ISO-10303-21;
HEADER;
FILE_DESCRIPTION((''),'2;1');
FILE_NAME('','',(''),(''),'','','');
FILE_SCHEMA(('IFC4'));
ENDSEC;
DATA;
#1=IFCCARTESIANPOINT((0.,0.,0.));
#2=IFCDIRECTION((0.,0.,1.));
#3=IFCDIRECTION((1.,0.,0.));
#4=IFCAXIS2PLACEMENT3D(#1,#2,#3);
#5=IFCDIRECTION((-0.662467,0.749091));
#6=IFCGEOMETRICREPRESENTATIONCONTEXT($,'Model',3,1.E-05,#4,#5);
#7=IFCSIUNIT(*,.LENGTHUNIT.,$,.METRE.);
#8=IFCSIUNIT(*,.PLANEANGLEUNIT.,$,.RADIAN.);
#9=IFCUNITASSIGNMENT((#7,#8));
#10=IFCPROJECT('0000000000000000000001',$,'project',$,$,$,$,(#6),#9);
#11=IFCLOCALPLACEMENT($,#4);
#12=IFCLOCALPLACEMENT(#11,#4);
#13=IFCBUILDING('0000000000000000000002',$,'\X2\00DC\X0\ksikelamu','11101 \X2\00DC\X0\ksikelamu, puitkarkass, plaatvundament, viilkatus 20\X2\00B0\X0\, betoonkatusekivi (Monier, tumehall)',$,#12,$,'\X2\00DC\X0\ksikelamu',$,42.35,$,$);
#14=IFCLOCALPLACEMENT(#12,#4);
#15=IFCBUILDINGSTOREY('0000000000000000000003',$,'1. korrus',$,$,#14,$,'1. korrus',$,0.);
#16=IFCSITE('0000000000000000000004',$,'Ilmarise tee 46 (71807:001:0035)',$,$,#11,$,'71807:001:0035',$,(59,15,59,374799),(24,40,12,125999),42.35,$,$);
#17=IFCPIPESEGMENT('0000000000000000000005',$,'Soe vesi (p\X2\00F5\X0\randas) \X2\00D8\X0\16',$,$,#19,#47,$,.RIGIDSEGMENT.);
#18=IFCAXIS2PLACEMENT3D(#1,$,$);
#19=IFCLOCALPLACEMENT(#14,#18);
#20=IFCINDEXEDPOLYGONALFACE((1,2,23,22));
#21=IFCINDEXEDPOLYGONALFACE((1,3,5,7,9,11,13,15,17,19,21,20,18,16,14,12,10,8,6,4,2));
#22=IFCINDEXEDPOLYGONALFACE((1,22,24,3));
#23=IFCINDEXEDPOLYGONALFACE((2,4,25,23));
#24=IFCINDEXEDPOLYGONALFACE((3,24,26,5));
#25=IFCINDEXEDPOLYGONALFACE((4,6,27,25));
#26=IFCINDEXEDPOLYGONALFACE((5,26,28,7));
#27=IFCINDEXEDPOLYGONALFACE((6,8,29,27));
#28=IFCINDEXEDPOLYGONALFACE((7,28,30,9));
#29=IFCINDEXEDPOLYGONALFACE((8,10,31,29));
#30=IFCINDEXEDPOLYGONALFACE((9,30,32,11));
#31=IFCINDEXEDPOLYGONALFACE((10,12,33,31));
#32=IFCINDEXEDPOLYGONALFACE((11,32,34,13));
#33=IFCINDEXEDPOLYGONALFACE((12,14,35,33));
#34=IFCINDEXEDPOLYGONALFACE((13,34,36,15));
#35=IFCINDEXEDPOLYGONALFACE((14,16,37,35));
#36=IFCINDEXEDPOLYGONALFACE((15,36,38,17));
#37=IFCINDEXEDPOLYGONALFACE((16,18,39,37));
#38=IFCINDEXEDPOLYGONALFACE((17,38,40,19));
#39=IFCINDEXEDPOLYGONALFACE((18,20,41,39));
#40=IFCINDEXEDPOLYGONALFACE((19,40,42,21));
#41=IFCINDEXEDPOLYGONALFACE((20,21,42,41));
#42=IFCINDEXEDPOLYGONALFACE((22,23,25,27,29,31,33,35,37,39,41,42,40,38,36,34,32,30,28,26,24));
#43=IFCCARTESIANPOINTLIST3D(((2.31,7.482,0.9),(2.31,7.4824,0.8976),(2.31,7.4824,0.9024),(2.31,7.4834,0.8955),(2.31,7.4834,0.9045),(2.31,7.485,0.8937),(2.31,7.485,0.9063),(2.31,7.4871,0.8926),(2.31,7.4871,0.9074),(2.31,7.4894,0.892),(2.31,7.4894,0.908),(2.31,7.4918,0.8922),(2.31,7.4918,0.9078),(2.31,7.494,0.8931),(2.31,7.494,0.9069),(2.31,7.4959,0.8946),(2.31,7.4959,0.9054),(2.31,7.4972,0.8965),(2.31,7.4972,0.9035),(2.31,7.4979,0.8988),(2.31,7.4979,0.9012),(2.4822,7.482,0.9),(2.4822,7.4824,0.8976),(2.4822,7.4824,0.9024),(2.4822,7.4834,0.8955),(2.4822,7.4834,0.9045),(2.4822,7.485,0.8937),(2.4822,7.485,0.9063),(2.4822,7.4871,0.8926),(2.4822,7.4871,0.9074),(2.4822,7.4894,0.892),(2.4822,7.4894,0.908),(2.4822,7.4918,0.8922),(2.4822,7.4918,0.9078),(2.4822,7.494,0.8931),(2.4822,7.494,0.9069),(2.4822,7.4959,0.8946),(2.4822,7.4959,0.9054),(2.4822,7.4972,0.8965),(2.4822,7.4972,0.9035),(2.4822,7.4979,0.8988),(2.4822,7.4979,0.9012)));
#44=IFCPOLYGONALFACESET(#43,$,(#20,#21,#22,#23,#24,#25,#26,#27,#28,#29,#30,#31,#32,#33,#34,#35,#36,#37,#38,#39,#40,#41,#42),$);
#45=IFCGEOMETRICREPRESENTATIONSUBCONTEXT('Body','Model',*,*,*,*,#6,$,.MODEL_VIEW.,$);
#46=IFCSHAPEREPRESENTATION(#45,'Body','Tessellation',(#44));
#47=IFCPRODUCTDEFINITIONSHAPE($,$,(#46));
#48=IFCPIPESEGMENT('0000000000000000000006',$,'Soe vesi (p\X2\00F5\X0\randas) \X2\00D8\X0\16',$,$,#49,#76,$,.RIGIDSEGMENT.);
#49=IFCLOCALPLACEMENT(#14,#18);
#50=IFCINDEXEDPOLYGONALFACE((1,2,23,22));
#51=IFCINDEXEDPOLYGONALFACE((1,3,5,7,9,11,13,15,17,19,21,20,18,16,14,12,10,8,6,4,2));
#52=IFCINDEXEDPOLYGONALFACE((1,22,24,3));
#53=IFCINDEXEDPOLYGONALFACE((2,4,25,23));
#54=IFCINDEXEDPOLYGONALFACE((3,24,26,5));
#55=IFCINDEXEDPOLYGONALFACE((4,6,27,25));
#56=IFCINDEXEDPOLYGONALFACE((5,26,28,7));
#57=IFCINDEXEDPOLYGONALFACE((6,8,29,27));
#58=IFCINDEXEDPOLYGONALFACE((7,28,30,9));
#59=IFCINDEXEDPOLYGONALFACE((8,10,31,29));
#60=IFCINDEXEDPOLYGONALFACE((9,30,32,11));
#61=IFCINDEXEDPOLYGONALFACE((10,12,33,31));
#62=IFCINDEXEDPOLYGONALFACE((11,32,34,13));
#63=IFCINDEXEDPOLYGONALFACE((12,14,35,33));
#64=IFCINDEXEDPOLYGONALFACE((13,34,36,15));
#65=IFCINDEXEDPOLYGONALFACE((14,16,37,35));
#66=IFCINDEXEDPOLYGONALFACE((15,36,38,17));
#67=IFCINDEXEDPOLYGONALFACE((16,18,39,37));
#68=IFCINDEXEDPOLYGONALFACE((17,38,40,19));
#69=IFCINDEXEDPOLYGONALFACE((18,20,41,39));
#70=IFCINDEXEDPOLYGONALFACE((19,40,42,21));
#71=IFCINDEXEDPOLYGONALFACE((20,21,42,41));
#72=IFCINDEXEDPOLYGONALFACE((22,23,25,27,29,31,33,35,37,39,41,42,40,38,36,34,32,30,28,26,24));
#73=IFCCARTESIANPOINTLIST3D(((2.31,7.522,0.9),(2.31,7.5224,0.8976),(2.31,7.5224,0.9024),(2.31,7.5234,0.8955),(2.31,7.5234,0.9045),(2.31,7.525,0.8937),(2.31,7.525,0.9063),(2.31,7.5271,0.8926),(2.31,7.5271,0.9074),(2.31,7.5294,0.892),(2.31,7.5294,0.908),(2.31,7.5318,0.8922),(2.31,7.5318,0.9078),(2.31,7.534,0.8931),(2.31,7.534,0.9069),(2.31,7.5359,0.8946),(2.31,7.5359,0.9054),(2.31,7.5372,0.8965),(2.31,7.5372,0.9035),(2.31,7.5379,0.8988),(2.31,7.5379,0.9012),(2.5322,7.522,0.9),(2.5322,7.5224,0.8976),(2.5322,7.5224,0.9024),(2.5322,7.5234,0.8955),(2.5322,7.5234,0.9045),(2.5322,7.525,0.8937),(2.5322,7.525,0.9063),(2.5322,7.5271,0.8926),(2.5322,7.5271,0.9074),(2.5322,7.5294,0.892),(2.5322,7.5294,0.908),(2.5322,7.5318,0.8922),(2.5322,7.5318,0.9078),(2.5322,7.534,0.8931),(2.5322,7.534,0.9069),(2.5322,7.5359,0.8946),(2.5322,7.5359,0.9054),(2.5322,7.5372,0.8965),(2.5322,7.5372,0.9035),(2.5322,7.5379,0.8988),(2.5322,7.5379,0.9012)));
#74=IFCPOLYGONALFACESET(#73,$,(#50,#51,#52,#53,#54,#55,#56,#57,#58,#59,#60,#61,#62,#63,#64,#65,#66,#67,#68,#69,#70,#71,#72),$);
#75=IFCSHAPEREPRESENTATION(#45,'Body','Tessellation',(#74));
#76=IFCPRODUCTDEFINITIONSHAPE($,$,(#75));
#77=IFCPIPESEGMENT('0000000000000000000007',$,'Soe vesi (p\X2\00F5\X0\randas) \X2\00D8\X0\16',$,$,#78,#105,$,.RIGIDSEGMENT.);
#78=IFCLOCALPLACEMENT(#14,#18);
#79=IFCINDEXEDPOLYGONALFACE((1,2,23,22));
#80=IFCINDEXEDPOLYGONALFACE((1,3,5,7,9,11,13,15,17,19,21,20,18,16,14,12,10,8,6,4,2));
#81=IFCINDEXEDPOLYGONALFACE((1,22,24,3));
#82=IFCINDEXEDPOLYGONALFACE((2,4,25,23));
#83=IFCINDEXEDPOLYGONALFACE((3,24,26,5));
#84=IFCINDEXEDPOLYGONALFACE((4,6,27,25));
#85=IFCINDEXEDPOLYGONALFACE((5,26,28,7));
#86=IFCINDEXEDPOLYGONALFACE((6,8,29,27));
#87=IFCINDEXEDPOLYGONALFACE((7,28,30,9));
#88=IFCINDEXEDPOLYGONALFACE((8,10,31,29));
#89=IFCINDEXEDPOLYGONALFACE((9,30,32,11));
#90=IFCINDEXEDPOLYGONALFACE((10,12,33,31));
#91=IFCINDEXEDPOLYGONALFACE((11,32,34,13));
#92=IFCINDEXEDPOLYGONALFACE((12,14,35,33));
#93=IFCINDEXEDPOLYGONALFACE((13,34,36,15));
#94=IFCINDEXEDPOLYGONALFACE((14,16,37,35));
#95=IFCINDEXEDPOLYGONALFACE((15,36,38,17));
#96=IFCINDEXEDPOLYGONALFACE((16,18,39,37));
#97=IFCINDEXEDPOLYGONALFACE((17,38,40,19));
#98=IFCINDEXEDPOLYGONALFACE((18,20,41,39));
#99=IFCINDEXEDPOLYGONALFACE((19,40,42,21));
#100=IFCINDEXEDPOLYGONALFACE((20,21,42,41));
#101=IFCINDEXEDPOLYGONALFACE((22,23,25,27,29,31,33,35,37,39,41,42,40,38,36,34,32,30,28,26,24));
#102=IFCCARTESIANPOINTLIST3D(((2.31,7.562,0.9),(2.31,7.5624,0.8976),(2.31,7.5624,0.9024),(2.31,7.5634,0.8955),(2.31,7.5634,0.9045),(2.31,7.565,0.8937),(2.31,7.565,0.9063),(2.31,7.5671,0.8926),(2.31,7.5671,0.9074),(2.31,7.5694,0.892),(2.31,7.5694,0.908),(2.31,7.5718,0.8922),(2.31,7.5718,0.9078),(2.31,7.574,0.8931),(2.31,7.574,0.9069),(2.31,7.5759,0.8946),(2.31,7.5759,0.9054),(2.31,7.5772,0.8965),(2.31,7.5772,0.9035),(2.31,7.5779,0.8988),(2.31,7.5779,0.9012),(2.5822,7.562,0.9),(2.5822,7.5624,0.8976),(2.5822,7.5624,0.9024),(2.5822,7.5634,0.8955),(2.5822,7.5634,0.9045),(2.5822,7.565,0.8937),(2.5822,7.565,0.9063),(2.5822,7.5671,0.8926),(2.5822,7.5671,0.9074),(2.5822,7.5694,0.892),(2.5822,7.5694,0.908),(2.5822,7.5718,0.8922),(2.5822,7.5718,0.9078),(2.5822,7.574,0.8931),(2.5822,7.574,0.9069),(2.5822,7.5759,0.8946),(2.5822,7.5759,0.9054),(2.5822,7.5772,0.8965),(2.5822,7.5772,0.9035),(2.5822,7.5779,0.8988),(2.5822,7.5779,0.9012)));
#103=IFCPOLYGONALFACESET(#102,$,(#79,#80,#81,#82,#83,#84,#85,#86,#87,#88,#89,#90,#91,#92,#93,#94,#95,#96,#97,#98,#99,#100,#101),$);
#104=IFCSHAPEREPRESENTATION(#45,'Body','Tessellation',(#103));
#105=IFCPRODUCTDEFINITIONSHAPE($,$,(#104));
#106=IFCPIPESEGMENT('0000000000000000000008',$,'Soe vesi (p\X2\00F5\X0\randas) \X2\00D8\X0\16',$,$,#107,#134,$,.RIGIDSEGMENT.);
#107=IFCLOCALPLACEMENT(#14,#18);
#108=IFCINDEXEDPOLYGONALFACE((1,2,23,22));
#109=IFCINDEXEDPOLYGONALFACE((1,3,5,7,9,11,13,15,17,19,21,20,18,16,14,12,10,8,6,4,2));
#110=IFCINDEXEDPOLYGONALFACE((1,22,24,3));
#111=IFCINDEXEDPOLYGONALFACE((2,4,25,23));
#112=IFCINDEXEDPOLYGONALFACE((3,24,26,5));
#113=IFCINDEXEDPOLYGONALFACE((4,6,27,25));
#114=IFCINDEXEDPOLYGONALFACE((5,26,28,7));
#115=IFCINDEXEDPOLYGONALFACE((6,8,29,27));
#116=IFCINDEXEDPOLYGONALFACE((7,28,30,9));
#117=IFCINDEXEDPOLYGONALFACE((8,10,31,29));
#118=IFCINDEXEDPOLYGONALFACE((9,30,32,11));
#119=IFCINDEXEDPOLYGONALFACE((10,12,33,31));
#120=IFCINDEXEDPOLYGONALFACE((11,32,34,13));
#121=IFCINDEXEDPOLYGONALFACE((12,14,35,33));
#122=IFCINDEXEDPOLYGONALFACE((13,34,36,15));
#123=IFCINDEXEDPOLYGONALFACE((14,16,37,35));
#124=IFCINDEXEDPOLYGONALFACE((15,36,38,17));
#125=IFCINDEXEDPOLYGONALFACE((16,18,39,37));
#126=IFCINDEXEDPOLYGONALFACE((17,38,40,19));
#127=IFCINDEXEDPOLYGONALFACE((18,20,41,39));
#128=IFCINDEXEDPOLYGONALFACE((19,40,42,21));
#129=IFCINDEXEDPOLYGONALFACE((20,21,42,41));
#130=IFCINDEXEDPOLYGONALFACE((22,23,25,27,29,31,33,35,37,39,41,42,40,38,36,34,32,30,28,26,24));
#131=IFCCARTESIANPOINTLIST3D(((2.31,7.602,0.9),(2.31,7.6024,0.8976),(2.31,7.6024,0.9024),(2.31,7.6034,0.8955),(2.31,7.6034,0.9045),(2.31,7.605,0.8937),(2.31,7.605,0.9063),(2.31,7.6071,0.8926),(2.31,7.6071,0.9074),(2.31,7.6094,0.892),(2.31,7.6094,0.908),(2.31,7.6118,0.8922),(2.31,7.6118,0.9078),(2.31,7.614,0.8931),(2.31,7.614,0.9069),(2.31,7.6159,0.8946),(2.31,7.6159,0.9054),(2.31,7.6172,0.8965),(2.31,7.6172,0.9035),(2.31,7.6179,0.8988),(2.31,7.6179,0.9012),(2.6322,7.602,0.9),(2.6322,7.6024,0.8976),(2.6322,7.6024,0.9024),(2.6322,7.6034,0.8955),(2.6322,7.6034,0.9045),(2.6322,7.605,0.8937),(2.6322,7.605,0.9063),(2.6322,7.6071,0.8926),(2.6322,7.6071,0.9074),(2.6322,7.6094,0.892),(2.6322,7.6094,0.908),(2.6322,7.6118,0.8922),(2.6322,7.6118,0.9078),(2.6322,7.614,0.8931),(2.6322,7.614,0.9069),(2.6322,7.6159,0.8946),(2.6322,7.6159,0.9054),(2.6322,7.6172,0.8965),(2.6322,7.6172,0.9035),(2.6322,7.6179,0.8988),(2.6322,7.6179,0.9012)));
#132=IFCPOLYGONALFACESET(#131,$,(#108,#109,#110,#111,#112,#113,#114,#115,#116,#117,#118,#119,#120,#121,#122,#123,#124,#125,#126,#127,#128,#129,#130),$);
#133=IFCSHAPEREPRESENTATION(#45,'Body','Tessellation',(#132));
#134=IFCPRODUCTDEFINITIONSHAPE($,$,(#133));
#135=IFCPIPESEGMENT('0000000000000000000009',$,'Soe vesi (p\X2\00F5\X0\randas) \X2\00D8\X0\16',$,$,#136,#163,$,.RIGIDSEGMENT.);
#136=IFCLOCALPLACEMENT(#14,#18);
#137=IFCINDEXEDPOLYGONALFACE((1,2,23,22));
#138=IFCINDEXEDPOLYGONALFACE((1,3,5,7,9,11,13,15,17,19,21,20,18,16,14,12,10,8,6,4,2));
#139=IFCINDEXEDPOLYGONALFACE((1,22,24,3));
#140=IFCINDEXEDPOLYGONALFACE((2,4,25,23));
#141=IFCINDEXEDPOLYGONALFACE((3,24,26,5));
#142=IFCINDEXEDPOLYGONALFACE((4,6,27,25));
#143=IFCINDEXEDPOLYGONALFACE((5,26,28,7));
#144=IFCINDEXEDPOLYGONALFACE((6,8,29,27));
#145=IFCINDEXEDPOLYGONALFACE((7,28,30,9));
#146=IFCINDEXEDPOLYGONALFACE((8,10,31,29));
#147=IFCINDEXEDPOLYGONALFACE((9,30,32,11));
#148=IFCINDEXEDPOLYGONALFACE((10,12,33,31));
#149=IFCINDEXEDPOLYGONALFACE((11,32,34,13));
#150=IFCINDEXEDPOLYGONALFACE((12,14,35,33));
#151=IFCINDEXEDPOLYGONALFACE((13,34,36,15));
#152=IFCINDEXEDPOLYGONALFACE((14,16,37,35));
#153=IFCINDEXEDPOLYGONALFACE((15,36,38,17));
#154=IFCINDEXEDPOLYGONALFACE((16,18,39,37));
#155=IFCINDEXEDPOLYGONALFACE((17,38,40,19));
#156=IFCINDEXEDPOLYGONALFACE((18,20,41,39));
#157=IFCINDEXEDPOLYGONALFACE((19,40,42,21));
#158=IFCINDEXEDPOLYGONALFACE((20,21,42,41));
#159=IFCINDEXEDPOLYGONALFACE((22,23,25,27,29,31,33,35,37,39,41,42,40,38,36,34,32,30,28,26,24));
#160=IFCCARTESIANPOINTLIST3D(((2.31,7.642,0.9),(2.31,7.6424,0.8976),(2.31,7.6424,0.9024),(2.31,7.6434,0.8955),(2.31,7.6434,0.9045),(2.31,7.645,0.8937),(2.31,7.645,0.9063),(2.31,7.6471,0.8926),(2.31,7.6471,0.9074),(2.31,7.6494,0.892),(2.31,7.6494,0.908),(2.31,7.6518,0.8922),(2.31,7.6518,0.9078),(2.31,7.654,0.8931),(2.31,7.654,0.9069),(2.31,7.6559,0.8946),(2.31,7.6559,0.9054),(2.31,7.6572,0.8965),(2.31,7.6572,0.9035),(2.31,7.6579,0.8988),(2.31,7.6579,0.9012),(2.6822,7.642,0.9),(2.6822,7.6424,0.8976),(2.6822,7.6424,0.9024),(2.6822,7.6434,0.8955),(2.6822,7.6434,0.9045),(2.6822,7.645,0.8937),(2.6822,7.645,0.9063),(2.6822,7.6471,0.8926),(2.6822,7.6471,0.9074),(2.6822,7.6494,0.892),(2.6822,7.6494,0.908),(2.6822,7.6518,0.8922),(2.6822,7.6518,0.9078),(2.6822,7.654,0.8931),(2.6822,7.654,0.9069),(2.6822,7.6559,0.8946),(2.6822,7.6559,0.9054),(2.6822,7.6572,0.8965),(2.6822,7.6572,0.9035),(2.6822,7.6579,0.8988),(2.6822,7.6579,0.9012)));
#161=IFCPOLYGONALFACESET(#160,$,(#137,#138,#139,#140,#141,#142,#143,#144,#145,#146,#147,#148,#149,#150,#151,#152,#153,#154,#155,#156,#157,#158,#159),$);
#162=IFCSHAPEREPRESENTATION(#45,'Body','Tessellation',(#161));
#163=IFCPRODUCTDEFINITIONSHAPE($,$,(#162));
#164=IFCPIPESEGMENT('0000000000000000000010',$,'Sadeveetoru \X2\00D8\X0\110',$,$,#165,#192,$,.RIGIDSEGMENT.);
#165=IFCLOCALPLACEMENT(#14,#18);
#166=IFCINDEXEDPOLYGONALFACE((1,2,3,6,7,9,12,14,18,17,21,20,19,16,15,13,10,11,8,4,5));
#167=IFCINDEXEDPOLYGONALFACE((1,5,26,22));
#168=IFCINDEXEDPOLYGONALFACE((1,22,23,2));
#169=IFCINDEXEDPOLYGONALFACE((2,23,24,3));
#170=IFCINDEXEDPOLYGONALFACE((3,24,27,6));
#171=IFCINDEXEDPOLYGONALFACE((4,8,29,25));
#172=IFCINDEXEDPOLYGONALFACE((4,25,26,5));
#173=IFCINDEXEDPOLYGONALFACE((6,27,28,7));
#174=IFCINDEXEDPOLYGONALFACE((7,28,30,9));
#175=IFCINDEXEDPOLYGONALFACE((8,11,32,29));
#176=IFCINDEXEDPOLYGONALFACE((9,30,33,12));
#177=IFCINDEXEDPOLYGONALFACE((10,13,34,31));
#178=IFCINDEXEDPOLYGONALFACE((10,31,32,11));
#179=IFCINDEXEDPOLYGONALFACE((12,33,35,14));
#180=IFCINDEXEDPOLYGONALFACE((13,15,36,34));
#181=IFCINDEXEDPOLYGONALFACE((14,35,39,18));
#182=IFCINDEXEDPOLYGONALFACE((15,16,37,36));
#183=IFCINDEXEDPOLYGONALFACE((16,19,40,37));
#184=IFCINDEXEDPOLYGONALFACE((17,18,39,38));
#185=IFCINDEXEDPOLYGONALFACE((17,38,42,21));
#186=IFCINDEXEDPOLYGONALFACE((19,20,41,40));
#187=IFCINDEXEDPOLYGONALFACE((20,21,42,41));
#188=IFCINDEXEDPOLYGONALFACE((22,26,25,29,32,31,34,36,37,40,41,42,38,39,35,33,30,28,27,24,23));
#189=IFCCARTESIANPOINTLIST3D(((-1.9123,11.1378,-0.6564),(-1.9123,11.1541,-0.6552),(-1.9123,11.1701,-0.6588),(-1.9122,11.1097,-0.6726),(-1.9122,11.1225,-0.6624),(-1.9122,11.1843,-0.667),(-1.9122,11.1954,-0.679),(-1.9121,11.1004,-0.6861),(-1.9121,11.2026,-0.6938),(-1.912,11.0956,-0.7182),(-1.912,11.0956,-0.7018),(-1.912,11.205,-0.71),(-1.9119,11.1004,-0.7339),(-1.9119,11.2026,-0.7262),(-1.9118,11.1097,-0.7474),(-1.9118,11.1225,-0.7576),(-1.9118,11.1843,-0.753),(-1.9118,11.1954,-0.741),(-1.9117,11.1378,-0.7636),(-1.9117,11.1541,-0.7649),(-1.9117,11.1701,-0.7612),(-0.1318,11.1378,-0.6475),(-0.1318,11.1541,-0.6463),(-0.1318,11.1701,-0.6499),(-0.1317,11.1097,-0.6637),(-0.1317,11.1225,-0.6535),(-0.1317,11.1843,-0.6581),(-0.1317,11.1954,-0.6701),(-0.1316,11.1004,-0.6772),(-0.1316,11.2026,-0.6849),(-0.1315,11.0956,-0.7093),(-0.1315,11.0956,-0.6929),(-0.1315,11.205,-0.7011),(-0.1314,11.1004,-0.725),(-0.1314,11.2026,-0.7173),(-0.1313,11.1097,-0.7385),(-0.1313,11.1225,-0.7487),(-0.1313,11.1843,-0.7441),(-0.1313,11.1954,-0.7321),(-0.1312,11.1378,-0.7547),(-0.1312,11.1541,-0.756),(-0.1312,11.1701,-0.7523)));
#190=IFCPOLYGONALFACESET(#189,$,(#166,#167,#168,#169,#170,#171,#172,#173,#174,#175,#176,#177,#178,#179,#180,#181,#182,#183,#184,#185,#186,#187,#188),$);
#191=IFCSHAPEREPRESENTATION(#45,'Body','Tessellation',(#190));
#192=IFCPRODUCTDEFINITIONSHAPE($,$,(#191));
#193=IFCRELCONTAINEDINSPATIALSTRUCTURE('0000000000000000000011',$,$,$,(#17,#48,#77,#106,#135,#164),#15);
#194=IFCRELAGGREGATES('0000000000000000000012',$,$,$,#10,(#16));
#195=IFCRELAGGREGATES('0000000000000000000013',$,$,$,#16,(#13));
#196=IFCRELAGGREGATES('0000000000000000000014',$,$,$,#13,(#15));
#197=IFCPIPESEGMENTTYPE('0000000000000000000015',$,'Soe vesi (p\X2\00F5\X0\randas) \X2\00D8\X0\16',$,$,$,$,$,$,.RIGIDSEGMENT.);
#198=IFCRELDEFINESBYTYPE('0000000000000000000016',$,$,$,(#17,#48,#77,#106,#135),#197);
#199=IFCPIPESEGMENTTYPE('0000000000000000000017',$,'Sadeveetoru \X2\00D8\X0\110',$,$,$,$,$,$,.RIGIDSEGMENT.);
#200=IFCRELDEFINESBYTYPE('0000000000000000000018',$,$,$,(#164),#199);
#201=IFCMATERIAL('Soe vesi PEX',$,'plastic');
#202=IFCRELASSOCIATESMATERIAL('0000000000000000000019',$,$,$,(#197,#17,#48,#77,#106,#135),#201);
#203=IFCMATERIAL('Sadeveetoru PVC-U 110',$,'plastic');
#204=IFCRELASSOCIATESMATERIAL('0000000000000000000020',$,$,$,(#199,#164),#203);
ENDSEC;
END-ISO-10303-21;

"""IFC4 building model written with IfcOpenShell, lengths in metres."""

from ifc_helpers import new_model, si_unit, direction, frame, origin_with_axes, place, context, subcontext, project, spatial, circle, extrude, material, type_object, element, save


model = new_model("IFC4")

# Units and contexts
model_context = context("Model", 3, precision=1e-05, world=origin_with_axes(), true_north=direction((-0.662467, 0.749091)))
body_context = subcontext(model_context, "Body", "Model", "MODEL_VIEW")
ifc_project = project(units=[si_unit("LENGTHUNIT", "METRE"), si_unit("PLANEANGLEUNIT", "RADIAN")], contexts=[model_context])

# Site, building, storey
site_placement = place(None, origin_with_axes())
site = spatial("IfcSite", under=ifc_project, at=site_placement, Name="Ilmarise tee 46 (71807:001:0035)", LongName="71807:001:0035", RefLatitude=(59, 15, 59, 374799), RefLongitude=(24, 40, 12, 125999), RefElevation=42.35)
building_placement = place(site_placement, origin_with_axes())
building = spatial("IfcBuilding", under=site, at=building_placement, Name="Üksikelamu", Description="11101 Üksikelamu, puitkarkass, plaatvundament, viilkatus 20°, betoonkatusekivi (Monier, tumehall)", LongName="Üksikelamu", ElevationOfRefHeight=42.35)
storey_placement = place(building_placement, origin_with_axes())
storey = spatial("IfcBuildingStorey", under=building, at=storey_placement, Name="1. korrus", LongName="1. korrus", Elevation=0.0)

# Shared definitions
ifc_material_1 = material(Name="Soe vesi PEX", Category="plastic")
ifc_material_2 = material(Name="Sadeveetoru PVC-U 110", Category="plastic")

# Pipe segments
pipe_segment_type_1 = type_object("IfcPipeSegmentType", Name="Soe vesi (põrandas) Ø16", PredefinedType="RIGIDSEGMENT", material=ifc_material_1)
pipe_segment_1_placement = place(storey_placement, frame((2.31, 7.49, 0.9), z_axis=(1.0, 0.0, 0.0), x_axis=(0.0, -1.0, 0.0)))
element("IfcPipeSegment", 1, at=pipe_segment_1_placement, inside=storey, type_object=pipe_segment_type_1, material=ifc_material_1, Name="Soe vesi (põrandas) Ø16", PredefinedType="RIGIDSEGMENT", context=body_context, shape_type="SweptSolid", body=[
    extrude(circle(Radius=0.008), origin_with_axes(), (0.0, 0.0, 1.0), 0.1722),
])
pipe_segment_2_placement = place(storey_placement, frame((2.31, 7.53, 0.9), z_axis=(1.0, 0.0, 0.0), x_axis=(0.0, -1.0, 0.0)))
element("IfcPipeSegment", 2, at=pipe_segment_2_placement, inside=storey, type_object=pipe_segment_type_1, material=ifc_material_1, Name="Soe vesi (põrandas) Ø16", PredefinedType="RIGIDSEGMENT", context=body_context, shape_type="SweptSolid", body=[
    extrude(circle(Radius=0.008), origin_with_axes(), (0.0, 0.0, 1.0), 0.2222),
])
pipe_segment_3_placement = place(storey_placement, frame((2.31, 7.57, 0.9), z_axis=(1.0, 0.0, 0.0), x_axis=(0.0, -1.0, 0.0)))
element("IfcPipeSegment", 3, at=pipe_segment_3_placement, inside=storey, type_object=pipe_segment_type_1, material=ifc_material_1, Name="Soe vesi (põrandas) Ø16", PredefinedType="RIGIDSEGMENT", context=body_context, shape_type="SweptSolid", body=[
    extrude(circle(Radius=0.008), origin_with_axes(), (0.0, 0.0, 1.0), 0.2722),
])
pipe_segment_4_placement = place(storey_placement, frame((2.31, 7.61, 0.9), z_axis=(1.0, 0.0, 0.0), x_axis=(0.0, -1.0, 0.0)))
element("IfcPipeSegment", 4, at=pipe_segment_4_placement, inside=storey, type_object=pipe_segment_type_1, material=ifc_material_1, Name="Soe vesi (põrandas) Ø16", PredefinedType="RIGIDSEGMENT", context=body_context, shape_type="SweptSolid", body=[
    extrude(circle(Radius=0.008), origin_with_axes(), (0.0, 0.0, 1.0), 0.3222),
])
pipe_segment_5_placement = place(storey_placement, frame((2.31, 7.65, 0.9), z_axis=(1.0, 0.0, 0.0), x_axis=(0.0, -1.0, 0.0)))
element("IfcPipeSegment", 5, at=pipe_segment_5_placement, inside=storey, type_object=pipe_segment_type_1, material=ifc_material_1, Name="Soe vesi (põrandas) Ø16", PredefinedType="RIGIDSEGMENT", context=body_context, shape_type="SweptSolid", body=[
    extrude(circle(Radius=0.008), origin_with_axes(), (0.0, 0.0, 1.0), 0.3722),
])
pipe_segment_type_2 = type_object("IfcPipeSegmentType", Name="Sadeveetoru Ø110", PredefinedType="RIGIDSEGMENT", material=ifc_material_2)
pipe_segment_6_placement = place(storey_placement, frame((-0.1315, 11.15, -0.7011), z_axis=(-0.999988, 0.0, -0.005), x_axis=(0.0, 1.0, 0.0)))
element("IfcPipeSegment", 6, at=pipe_segment_6_placement, inside=storey, type_object=pipe_segment_type_2, material=ifc_material_2, Name="Sadeveetoru Ø110", PredefinedType="RIGIDSEGMENT", context=body_context, shape_type="SweptSolid", body=[
    extrude(circle(Radius=0.055), origin_with_axes(), (0.0, 0.0, 1.0), 1.7805),
])

save(model, "model.ifc")
